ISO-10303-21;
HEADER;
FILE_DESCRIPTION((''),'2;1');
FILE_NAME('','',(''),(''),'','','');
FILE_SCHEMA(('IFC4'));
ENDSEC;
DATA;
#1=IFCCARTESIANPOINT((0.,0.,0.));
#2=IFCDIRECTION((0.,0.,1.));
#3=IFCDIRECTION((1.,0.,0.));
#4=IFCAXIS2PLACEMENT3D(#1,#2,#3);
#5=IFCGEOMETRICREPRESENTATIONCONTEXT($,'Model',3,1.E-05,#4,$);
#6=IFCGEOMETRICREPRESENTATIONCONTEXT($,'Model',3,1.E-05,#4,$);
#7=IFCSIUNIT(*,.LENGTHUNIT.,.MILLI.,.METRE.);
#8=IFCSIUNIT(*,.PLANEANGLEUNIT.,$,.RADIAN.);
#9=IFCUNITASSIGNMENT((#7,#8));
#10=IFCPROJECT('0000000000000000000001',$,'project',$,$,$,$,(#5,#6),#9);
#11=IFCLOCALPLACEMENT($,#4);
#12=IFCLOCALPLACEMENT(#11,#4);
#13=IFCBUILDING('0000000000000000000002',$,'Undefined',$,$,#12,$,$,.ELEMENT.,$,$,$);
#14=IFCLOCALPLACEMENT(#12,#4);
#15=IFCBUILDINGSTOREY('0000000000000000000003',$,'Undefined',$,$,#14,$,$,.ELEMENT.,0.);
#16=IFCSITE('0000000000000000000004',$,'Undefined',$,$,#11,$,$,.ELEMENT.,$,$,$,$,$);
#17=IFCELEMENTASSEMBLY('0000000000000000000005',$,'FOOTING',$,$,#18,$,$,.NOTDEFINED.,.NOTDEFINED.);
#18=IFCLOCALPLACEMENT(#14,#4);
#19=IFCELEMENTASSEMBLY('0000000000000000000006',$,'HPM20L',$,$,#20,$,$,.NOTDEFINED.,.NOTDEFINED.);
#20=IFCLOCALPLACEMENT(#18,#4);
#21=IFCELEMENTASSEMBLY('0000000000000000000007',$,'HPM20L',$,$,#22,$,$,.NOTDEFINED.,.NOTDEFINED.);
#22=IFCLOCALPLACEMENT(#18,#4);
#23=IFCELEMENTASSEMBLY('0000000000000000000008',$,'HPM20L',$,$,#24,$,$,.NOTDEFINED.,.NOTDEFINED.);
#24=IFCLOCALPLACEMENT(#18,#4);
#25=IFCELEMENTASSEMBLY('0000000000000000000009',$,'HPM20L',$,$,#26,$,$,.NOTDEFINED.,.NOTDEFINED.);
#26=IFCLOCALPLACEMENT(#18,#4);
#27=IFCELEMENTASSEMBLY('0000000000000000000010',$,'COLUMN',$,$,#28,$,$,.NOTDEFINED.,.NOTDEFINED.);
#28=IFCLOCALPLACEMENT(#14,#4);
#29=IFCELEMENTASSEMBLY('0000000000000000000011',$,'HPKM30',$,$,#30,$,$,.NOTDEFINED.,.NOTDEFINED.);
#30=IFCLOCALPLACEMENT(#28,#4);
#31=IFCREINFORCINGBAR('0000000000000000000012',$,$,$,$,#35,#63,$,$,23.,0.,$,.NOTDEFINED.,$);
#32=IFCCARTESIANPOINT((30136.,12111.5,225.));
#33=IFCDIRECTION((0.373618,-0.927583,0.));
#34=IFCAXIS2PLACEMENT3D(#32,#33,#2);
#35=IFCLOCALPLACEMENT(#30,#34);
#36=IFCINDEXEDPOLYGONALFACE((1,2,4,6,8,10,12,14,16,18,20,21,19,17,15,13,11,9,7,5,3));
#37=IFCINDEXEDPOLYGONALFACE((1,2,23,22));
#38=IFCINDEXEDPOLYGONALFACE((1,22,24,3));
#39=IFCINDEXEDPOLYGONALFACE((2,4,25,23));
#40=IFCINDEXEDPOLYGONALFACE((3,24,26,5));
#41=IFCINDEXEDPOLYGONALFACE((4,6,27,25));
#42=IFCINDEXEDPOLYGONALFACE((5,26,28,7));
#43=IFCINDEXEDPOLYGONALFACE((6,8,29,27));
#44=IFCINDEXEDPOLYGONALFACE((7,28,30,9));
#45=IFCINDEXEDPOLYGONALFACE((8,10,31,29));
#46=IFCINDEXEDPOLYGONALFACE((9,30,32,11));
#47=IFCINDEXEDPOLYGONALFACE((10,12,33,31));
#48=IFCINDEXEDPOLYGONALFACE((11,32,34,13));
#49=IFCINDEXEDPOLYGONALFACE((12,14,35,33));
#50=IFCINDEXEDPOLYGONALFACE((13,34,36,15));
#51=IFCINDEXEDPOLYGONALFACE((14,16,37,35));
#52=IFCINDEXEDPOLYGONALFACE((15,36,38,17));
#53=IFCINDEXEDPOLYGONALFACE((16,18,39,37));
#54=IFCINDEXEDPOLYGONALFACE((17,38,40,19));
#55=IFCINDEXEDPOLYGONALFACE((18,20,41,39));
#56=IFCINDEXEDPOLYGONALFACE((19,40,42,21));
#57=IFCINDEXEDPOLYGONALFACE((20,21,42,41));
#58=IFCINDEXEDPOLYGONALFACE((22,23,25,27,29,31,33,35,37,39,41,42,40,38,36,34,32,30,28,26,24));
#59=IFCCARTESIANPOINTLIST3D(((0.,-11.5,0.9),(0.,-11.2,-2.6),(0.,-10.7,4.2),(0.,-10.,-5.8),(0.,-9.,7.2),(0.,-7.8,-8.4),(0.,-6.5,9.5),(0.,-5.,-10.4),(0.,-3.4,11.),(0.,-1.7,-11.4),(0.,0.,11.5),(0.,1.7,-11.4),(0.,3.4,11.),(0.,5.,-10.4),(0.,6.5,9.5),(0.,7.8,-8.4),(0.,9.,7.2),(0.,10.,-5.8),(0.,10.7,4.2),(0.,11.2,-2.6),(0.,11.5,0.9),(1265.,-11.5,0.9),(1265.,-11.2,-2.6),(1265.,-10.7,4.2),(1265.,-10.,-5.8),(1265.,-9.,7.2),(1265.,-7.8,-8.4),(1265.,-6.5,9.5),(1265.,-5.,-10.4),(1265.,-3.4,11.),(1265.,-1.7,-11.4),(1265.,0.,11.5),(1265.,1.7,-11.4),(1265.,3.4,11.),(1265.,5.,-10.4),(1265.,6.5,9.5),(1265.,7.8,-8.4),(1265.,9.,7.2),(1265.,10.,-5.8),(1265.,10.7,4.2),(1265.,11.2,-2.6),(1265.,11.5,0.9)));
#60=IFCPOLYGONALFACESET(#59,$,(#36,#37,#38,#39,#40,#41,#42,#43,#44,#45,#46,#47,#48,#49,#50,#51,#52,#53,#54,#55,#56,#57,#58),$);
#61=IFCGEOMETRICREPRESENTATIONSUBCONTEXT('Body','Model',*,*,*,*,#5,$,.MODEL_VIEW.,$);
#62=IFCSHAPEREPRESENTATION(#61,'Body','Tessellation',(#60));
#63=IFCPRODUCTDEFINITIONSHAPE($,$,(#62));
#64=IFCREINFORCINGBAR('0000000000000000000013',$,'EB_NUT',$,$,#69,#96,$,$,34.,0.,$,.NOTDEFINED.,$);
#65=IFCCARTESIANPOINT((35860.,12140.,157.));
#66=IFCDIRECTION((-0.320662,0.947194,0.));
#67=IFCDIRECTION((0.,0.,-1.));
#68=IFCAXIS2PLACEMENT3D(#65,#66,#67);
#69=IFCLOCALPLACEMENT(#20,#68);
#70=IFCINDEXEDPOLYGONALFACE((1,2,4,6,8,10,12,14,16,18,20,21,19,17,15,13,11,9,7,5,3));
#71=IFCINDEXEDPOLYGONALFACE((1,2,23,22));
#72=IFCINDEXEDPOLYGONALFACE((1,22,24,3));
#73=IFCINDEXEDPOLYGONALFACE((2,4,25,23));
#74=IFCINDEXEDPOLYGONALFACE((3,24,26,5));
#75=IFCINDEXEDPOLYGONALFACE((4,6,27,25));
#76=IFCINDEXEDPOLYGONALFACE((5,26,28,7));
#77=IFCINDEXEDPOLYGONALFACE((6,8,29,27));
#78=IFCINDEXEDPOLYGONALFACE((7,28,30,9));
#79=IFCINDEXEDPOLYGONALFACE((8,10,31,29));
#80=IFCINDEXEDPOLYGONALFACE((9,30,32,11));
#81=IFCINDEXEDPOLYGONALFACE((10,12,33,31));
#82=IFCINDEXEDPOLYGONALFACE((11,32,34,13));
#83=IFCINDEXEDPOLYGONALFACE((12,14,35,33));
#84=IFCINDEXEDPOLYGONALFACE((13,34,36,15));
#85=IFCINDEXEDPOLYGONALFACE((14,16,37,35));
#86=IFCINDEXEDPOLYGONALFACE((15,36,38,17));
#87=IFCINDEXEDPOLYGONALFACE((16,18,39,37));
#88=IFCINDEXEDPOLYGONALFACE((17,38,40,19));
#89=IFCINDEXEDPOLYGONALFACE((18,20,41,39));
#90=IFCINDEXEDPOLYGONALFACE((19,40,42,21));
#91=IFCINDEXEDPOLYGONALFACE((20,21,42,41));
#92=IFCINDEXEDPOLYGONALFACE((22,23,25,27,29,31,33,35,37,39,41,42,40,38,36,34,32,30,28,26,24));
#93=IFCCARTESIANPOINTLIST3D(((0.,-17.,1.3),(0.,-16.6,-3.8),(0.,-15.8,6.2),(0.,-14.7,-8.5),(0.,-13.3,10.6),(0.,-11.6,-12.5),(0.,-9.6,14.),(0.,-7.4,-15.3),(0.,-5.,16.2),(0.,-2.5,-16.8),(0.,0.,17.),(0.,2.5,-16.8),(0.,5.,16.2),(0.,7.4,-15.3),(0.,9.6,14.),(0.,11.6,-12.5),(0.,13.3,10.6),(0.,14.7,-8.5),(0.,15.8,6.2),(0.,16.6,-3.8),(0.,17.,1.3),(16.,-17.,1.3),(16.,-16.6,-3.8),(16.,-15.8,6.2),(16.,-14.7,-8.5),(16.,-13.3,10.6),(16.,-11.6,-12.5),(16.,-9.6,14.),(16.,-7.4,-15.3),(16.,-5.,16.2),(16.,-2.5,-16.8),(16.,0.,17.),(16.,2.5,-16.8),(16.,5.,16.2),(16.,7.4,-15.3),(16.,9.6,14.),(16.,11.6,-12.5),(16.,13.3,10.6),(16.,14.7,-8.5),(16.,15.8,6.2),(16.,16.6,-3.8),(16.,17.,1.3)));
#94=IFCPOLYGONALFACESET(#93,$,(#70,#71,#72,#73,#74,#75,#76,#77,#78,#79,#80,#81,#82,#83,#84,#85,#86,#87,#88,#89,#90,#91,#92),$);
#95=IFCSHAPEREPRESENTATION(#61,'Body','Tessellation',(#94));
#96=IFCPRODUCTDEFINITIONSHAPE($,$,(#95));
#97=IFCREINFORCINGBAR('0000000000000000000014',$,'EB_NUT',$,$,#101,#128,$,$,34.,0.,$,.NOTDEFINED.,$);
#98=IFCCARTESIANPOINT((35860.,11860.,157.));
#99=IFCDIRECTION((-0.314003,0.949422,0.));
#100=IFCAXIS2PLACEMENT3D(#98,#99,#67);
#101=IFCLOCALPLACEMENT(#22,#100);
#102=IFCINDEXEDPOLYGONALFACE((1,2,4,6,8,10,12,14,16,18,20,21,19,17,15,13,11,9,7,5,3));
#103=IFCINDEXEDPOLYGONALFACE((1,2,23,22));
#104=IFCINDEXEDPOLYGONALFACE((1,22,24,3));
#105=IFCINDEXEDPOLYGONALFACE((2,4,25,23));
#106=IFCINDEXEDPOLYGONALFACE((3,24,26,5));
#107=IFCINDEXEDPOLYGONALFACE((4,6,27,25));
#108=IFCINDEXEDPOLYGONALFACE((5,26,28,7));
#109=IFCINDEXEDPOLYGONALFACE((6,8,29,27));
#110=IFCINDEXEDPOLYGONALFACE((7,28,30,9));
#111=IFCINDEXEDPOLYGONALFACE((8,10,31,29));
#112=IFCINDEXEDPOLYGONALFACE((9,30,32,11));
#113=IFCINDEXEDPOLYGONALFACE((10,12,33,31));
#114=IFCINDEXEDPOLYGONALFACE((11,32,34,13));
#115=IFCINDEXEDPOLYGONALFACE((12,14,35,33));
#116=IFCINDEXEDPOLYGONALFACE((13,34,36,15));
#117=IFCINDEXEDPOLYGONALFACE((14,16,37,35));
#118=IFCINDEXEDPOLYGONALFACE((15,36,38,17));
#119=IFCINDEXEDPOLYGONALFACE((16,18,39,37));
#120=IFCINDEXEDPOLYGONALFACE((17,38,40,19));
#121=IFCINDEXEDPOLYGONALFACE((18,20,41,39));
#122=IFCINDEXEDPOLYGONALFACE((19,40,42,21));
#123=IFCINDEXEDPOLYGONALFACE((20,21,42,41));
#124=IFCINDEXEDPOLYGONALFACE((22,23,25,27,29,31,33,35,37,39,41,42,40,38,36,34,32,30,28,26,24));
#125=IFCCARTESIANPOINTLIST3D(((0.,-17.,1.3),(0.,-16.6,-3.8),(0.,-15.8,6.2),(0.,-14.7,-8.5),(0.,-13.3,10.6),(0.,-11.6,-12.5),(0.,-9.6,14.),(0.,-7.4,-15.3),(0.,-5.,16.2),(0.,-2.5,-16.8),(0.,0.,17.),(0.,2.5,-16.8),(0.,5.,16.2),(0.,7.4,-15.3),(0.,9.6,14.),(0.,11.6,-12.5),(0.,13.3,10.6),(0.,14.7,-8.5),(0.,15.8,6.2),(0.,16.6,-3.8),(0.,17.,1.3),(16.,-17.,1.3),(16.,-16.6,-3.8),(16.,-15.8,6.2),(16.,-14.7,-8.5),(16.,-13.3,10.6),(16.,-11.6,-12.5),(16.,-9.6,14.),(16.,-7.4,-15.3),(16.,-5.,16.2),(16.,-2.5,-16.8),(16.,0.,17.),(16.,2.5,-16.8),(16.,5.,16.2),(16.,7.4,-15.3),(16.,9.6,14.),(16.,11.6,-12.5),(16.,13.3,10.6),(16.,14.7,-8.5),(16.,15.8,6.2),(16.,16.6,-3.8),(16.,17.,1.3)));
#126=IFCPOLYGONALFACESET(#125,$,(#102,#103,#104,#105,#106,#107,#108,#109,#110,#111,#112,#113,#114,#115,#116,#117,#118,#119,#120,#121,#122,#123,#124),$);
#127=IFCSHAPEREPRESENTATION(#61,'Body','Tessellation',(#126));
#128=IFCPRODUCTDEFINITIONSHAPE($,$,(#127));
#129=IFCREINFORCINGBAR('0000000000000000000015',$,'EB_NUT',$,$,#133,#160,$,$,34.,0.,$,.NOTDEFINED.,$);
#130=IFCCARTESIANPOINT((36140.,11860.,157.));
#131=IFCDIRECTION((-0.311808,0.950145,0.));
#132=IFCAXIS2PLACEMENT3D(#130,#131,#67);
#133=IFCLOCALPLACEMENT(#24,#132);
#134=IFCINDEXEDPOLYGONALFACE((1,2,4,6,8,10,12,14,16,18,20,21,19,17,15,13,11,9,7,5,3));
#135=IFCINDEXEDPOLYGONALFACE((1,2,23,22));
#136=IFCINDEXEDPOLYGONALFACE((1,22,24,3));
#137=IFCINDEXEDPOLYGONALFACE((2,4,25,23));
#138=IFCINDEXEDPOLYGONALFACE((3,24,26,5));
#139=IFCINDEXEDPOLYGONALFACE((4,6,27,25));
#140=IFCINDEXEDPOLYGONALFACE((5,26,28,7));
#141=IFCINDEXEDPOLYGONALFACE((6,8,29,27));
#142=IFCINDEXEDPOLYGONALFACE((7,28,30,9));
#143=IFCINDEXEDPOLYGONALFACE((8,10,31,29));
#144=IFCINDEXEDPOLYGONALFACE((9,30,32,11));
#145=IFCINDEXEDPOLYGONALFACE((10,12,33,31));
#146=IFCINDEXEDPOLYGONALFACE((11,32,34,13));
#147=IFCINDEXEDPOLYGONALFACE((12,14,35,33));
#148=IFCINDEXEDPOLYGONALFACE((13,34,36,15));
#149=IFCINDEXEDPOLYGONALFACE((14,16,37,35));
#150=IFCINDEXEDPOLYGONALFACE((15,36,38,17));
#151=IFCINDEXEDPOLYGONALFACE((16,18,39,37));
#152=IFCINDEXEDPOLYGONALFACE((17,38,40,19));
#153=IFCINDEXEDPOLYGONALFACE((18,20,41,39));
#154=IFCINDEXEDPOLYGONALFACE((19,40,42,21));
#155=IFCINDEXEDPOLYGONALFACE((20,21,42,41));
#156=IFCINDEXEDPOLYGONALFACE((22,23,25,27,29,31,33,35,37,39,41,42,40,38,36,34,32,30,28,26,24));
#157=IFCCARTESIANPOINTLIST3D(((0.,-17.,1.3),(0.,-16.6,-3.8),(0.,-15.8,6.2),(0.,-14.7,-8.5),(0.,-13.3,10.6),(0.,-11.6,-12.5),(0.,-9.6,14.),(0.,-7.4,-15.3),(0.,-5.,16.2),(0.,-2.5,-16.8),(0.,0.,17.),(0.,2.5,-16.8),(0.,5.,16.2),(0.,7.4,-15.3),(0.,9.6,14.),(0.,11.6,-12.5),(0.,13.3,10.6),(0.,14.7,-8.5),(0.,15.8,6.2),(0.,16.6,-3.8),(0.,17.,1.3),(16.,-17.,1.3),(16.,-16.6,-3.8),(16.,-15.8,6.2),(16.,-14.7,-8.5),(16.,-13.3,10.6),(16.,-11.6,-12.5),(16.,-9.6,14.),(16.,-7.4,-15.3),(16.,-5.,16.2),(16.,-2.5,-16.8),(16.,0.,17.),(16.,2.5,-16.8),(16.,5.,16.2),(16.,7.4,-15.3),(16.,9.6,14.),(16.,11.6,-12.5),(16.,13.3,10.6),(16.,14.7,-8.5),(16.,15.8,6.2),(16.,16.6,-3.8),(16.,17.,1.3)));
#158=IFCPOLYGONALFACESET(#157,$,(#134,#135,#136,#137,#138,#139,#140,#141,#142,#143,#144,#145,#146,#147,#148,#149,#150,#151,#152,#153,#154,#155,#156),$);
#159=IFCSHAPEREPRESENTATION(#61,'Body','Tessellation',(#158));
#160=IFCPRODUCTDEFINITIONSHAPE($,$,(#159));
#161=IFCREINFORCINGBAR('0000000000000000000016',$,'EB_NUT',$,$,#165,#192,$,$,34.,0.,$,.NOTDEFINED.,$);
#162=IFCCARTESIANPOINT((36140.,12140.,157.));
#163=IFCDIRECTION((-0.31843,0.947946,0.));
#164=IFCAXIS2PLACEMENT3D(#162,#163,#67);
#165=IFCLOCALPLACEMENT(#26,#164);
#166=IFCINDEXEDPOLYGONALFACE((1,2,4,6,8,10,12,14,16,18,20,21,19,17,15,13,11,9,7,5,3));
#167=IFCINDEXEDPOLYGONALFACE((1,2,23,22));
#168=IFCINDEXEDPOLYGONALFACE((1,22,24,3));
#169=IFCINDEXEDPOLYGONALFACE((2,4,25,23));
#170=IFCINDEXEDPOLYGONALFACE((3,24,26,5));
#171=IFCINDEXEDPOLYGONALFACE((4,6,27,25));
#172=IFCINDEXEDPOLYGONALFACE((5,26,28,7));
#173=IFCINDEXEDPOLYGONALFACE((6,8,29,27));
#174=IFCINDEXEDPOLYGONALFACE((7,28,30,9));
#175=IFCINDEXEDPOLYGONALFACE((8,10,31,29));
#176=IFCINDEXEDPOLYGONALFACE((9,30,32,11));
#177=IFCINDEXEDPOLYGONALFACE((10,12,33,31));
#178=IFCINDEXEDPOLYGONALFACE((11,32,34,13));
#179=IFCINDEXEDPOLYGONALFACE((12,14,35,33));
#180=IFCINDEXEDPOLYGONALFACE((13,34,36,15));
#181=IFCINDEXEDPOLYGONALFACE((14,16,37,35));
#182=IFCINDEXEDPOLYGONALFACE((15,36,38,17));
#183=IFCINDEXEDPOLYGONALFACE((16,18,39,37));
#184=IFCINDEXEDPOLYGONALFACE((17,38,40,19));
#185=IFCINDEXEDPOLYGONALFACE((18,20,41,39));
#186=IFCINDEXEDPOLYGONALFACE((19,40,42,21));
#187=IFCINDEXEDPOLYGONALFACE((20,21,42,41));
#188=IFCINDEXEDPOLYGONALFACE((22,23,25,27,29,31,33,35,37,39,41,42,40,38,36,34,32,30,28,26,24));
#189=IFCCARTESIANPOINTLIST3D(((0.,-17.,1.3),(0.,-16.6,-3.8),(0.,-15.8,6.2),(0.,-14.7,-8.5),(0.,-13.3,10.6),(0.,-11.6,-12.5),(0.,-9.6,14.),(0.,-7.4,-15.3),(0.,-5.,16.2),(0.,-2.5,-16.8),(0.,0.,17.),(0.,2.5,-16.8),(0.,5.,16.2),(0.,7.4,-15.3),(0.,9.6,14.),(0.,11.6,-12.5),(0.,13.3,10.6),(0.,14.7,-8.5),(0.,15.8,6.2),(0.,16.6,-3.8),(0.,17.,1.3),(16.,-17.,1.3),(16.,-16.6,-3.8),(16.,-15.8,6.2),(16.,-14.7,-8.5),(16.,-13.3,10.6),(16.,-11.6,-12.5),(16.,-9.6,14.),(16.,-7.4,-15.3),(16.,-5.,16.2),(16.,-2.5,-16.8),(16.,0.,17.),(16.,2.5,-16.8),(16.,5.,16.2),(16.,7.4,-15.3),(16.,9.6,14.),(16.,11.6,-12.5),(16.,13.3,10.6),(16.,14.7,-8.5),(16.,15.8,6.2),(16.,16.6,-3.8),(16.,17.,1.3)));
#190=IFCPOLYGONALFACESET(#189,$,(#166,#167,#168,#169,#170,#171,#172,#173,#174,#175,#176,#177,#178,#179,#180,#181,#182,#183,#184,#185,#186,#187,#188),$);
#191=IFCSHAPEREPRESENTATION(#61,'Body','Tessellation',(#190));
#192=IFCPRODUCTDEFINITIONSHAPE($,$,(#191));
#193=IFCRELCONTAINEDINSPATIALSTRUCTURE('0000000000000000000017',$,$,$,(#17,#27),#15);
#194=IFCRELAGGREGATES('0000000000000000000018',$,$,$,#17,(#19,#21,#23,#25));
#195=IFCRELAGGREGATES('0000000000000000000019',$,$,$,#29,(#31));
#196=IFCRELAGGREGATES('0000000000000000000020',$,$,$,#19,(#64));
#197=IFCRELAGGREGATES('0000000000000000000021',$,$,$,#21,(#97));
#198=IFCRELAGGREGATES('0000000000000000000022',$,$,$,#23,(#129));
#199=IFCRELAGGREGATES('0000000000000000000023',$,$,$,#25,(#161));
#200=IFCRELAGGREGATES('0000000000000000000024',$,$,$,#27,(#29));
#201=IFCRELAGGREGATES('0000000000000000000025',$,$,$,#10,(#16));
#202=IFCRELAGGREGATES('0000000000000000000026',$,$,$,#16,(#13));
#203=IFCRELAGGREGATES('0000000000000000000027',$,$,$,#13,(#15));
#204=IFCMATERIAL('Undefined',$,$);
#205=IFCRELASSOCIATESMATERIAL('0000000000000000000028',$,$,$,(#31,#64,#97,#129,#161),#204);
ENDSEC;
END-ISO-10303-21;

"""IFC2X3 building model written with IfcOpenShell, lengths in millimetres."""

from ifc_helpers import new_model, entity, si_unit, frame, origin_with_axes, place, context, subcontext, project, spatial, source, transform, mapped, material, element, aggregate, save


model = new_model("IFC2X3")

# Units and contexts
model_context_1 = context("Model", 3, precision=1e-05, world=origin_with_axes())
model_context_2 = context("Model", 3, precision=1e-05, world=origin_with_axes())
body_context = subcontext(model_context_1, "Body", "Model", "MODEL_VIEW")
ifc_project = project(units=[si_unit("LENGTHUNIT", "METRE", prefix="MILLI"), si_unit("PLANEANGLEUNIT", "RADIAN")], contexts=[model_context_1, model_context_2])

# Site, building, storey
site_placement = place(None, origin_with_axes())
site = spatial("IfcSite", under=ifc_project, at=site_placement, Name="Undefined", CompositionType="ELEMENT")
building_placement = place(site_placement, origin_with_axes())
building = spatial("IfcBuilding", under=site, at=building_placement, Name="Undefined", CompositionType="ELEMENT")
storey_placement = place(building_placement, origin_with_axes())
storey = spatial("IfcBuildingStorey", under=building, at=storey_placement, Name="Undefined", CompositionType="ELEMENT", Elevation=0.0)

# Element assemblies
assembly_1_placement = place(storey_placement, origin_with_axes())
assembly_1 = element("IfcElementAssembly", 1, at=assembly_1_placement, inside=storey, Name="FOOTING", AssemblyPlace="NOTDEFINED", PredefinedType="NOTDEFINED")
assembly_2_placement = place(assembly_1_placement, origin_with_axes())
assembly_2 = element("IfcElementAssembly", 2, at=assembly_2_placement, Name="HPM20L", AssemblyPlace="NOTDEFINED", PredefinedType="NOTDEFINED")
assembly_3_placement = place(assembly_1_placement, origin_with_axes())
assembly_3 = element("IfcElementAssembly", 3, at=assembly_3_placement, Name="HPM20L", AssemblyPlace="NOTDEFINED", PredefinedType="NOTDEFINED")
assembly_4_placement = place(assembly_1_placement, origin_with_axes())
assembly_4 = element("IfcElementAssembly", 4, at=assembly_4_placement, Name="HPM20L", AssemblyPlace="NOTDEFINED", PredefinedType="NOTDEFINED")
assembly_5_placement = place(assembly_1_placement, origin_with_axes())
assembly_5 = element("IfcElementAssembly", 5, at=assembly_5_placement, Name="HPM20L", AssemblyPlace="NOTDEFINED", PredefinedType="NOTDEFINED")
aggregate(assembly_1, [assembly_2, assembly_3, assembly_4, assembly_5])

# Shared definitions
ifc_material_1 = material(Name="Undefined")

# Element assemblies, reinforcing bar
assembly_6_placement = place(storey_placement, origin_with_axes())
assembly_6 = element("IfcElementAssembly", 6, at=assembly_6_placement, inside=storey, Name="COLUMN", AssemblyPlace="NOTDEFINED", PredefinedType="NOTDEFINED")
assembly_7_placement = place(assembly_6_placement, origin_with_axes())
assembly_7 = element("IfcElementAssembly", 7, at=assembly_7_placement, Name="HPKM30", AssemblyPlace="NOTDEFINED", PredefinedType="NOTDEFINED")
shared_shape_1 = source(origin_with_axes(), body_context, "Body", "AdvancedSweptSolid", [
    entity("IfcSweptDiskSolid", entity("IfcTrimmedCurve", entity("IfcLine", entity("IfcCartesianPoint", [0.0, 0.0, 0.0]), entity("IfcVector", entity("IfcDirection", [1.0, 0.0, 0.0]), 1.0)), [entity("IfcParameterValue", 0.0)], [entity("IfcParameterValue", 1265.0)], True, "PARAMETER"), 11.5, None, 0.0, 1265.0),
])
reinforcing_bar_1_placement = place(assembly_7_placement, frame((30136.0, 12111.5, 225.0), z_axis=(0.373618, -0.927583, 0.0), x_axis=(0.0, 0.0, 1.0)))
reinforcing_bar_1 = element("IfcReinforcingBar", 8, at=reinforcing_bar_1_placement, material=ifc_material_1, BarRole="NOTDEFINED", CrossSectionArea=0.0, NominalDiameter=23.0, context=body_context, shape_type="MappedRepresentation", body=[
    mapped(shared_shape_1, transform((0.0, 0.0, 0.0))),
])
aggregate(assembly_7, [reinforcing_bar_1])

# Reinforcing bars
shared_shape_2 = source(origin_with_axes(), body_context, "Body", "AdvancedSweptSolid", [
    entity("IfcSweptDiskSolid", entity("IfcTrimmedCurve", entity("IfcLine", entity("IfcCartesianPoint", [0.0, 0.0, 0.0]), entity("IfcVector", entity("IfcDirection", [1.0, 0.0, 0.0]), 1.0)), [entity("IfcParameterValue", 0.0)], [entity("IfcParameterValue", 16.0)], True, "PARAMETER"), 17.0, None, 0.0, 16.0),
])
reinforcing_bar_2_placement = place(assembly_2_placement, frame((35860.0, 12140.0, 157.0), z_axis=(-0.320662, 0.947194, 0.0), x_axis=(0.0, 0.0, -1.0)))
reinforcing_bar_2 = element("IfcReinforcingBar", 9, at=reinforcing_bar_2_placement, material=ifc_material_1, Name="EB_NUT", BarRole="NOTDEFINED", CrossSectionArea=0.0, NominalDiameter=34.0, context=body_context, shape_type="MappedRepresentation", body=[
    mapped(shared_shape_2, transform((0.0, 0.0, 0.0))),
])
aggregate(assembly_2, [reinforcing_bar_2])
shared_shape_3 = source(origin_with_axes(), body_context, "Body", "AdvancedSweptSolid", [
    entity("IfcSweptDiskSolid", entity("IfcTrimmedCurve", entity("IfcLine", entity("IfcCartesianPoint", [0.0, 0.0, 0.0]), entity("IfcVector", entity("IfcDirection", [1.0, 0.0, 0.0]), 1.0)), [entity("IfcParameterValue", 0.0)], [entity("IfcParameterValue", 16.0)], True, "PARAMETER"), 17.0, None, 0.0, 16.0),
])
reinforcing_bar_3_placement = place(assembly_3_placement, frame((35860.0, 11860.0, 157.0), z_axis=(-0.314003, 0.949422, 0.0), x_axis=(0.0, 0.0, -1.0)))
reinforcing_bar_3 = element("IfcReinforcingBar", 10, at=reinforcing_bar_3_placement, material=ifc_material_1, Name="EB_NUT", BarRole="NOTDEFINED", CrossSectionArea=0.0, NominalDiameter=34.0, context=body_context, shape_type="MappedRepresentation", body=[
    mapped(shared_shape_3, transform((0.0, 0.0, 0.0))),
])
aggregate(assembly_3, [reinforcing_bar_3])
shared_shape_4 = source(origin_with_axes(), body_context, "Body", "AdvancedSweptSolid", [
    entity("IfcSweptDiskSolid", entity("IfcTrimmedCurve", entity("IfcLine", entity("IfcCartesianPoint", [0.0, 0.0, 0.0]), entity("IfcVector", entity("IfcDirection", [1.0, 0.0, 0.0]), 1.0)), [entity("IfcParameterValue", 0.0)], [entity("IfcParameterValue", 16.0)], True, "PARAMETER"), 17.0, None, 0.0, 16.0),
])
reinforcing_bar_4_placement = place(assembly_4_placement, frame((36140.0, 11860.0, 157.0), z_axis=(-0.311808, 0.950145, 0.0), x_axis=(0.0, 0.0, -1.0)))
reinforcing_bar_4 = element("IfcReinforcingBar", 11, at=reinforcing_bar_4_placement, material=ifc_material_1, Name="EB_NUT", BarRole="NOTDEFINED", CrossSectionArea=0.0, NominalDiameter=34.0, context=body_context, shape_type="MappedRepresentation", body=[
    mapped(shared_shape_4, transform((0.0, 0.0, 0.0))),
])
aggregate(assembly_4, [reinforcing_bar_4])
shared_shape_5 = source(origin_with_axes(), body_context, "Body", "AdvancedSweptSolid", [
    entity("IfcSweptDiskSolid", entity("IfcTrimmedCurve", entity("IfcLine", entity("IfcCartesianPoint", [0.0, 0.0, 0.0]), entity("IfcVector", entity("IfcDirection", [1.0, 0.0, 0.0]), 1.0)), [entity("IfcParameterValue", 0.0)], [entity("IfcParameterValue", 16.0)], True, "PARAMETER"), 17.0, None, 0.0, 16.0),
])
reinforcing_bar_5_placement = place(assembly_5_placement, frame((36140.0, 12140.0, 157.0), z_axis=(-0.31843, 0.947946, 0.0), x_axis=(0.0, 0.0, -1.0)))
reinforcing_bar_5 = element("IfcReinforcingBar", 12, at=reinforcing_bar_5_placement, material=ifc_material_1, Name="EB_NUT", BarRole="NOTDEFINED", CrossSectionArea=0.0, NominalDiameter=34.0, context=body_context, shape_type="MappedRepresentation", body=[
    mapped(shared_shape_5, transform((0.0, 0.0, 0.0))),
])
aggregate(assembly_5, [reinforcing_bar_5])

aggregate(assembly_6, [assembly_7])

save(model, "model.ifc")
